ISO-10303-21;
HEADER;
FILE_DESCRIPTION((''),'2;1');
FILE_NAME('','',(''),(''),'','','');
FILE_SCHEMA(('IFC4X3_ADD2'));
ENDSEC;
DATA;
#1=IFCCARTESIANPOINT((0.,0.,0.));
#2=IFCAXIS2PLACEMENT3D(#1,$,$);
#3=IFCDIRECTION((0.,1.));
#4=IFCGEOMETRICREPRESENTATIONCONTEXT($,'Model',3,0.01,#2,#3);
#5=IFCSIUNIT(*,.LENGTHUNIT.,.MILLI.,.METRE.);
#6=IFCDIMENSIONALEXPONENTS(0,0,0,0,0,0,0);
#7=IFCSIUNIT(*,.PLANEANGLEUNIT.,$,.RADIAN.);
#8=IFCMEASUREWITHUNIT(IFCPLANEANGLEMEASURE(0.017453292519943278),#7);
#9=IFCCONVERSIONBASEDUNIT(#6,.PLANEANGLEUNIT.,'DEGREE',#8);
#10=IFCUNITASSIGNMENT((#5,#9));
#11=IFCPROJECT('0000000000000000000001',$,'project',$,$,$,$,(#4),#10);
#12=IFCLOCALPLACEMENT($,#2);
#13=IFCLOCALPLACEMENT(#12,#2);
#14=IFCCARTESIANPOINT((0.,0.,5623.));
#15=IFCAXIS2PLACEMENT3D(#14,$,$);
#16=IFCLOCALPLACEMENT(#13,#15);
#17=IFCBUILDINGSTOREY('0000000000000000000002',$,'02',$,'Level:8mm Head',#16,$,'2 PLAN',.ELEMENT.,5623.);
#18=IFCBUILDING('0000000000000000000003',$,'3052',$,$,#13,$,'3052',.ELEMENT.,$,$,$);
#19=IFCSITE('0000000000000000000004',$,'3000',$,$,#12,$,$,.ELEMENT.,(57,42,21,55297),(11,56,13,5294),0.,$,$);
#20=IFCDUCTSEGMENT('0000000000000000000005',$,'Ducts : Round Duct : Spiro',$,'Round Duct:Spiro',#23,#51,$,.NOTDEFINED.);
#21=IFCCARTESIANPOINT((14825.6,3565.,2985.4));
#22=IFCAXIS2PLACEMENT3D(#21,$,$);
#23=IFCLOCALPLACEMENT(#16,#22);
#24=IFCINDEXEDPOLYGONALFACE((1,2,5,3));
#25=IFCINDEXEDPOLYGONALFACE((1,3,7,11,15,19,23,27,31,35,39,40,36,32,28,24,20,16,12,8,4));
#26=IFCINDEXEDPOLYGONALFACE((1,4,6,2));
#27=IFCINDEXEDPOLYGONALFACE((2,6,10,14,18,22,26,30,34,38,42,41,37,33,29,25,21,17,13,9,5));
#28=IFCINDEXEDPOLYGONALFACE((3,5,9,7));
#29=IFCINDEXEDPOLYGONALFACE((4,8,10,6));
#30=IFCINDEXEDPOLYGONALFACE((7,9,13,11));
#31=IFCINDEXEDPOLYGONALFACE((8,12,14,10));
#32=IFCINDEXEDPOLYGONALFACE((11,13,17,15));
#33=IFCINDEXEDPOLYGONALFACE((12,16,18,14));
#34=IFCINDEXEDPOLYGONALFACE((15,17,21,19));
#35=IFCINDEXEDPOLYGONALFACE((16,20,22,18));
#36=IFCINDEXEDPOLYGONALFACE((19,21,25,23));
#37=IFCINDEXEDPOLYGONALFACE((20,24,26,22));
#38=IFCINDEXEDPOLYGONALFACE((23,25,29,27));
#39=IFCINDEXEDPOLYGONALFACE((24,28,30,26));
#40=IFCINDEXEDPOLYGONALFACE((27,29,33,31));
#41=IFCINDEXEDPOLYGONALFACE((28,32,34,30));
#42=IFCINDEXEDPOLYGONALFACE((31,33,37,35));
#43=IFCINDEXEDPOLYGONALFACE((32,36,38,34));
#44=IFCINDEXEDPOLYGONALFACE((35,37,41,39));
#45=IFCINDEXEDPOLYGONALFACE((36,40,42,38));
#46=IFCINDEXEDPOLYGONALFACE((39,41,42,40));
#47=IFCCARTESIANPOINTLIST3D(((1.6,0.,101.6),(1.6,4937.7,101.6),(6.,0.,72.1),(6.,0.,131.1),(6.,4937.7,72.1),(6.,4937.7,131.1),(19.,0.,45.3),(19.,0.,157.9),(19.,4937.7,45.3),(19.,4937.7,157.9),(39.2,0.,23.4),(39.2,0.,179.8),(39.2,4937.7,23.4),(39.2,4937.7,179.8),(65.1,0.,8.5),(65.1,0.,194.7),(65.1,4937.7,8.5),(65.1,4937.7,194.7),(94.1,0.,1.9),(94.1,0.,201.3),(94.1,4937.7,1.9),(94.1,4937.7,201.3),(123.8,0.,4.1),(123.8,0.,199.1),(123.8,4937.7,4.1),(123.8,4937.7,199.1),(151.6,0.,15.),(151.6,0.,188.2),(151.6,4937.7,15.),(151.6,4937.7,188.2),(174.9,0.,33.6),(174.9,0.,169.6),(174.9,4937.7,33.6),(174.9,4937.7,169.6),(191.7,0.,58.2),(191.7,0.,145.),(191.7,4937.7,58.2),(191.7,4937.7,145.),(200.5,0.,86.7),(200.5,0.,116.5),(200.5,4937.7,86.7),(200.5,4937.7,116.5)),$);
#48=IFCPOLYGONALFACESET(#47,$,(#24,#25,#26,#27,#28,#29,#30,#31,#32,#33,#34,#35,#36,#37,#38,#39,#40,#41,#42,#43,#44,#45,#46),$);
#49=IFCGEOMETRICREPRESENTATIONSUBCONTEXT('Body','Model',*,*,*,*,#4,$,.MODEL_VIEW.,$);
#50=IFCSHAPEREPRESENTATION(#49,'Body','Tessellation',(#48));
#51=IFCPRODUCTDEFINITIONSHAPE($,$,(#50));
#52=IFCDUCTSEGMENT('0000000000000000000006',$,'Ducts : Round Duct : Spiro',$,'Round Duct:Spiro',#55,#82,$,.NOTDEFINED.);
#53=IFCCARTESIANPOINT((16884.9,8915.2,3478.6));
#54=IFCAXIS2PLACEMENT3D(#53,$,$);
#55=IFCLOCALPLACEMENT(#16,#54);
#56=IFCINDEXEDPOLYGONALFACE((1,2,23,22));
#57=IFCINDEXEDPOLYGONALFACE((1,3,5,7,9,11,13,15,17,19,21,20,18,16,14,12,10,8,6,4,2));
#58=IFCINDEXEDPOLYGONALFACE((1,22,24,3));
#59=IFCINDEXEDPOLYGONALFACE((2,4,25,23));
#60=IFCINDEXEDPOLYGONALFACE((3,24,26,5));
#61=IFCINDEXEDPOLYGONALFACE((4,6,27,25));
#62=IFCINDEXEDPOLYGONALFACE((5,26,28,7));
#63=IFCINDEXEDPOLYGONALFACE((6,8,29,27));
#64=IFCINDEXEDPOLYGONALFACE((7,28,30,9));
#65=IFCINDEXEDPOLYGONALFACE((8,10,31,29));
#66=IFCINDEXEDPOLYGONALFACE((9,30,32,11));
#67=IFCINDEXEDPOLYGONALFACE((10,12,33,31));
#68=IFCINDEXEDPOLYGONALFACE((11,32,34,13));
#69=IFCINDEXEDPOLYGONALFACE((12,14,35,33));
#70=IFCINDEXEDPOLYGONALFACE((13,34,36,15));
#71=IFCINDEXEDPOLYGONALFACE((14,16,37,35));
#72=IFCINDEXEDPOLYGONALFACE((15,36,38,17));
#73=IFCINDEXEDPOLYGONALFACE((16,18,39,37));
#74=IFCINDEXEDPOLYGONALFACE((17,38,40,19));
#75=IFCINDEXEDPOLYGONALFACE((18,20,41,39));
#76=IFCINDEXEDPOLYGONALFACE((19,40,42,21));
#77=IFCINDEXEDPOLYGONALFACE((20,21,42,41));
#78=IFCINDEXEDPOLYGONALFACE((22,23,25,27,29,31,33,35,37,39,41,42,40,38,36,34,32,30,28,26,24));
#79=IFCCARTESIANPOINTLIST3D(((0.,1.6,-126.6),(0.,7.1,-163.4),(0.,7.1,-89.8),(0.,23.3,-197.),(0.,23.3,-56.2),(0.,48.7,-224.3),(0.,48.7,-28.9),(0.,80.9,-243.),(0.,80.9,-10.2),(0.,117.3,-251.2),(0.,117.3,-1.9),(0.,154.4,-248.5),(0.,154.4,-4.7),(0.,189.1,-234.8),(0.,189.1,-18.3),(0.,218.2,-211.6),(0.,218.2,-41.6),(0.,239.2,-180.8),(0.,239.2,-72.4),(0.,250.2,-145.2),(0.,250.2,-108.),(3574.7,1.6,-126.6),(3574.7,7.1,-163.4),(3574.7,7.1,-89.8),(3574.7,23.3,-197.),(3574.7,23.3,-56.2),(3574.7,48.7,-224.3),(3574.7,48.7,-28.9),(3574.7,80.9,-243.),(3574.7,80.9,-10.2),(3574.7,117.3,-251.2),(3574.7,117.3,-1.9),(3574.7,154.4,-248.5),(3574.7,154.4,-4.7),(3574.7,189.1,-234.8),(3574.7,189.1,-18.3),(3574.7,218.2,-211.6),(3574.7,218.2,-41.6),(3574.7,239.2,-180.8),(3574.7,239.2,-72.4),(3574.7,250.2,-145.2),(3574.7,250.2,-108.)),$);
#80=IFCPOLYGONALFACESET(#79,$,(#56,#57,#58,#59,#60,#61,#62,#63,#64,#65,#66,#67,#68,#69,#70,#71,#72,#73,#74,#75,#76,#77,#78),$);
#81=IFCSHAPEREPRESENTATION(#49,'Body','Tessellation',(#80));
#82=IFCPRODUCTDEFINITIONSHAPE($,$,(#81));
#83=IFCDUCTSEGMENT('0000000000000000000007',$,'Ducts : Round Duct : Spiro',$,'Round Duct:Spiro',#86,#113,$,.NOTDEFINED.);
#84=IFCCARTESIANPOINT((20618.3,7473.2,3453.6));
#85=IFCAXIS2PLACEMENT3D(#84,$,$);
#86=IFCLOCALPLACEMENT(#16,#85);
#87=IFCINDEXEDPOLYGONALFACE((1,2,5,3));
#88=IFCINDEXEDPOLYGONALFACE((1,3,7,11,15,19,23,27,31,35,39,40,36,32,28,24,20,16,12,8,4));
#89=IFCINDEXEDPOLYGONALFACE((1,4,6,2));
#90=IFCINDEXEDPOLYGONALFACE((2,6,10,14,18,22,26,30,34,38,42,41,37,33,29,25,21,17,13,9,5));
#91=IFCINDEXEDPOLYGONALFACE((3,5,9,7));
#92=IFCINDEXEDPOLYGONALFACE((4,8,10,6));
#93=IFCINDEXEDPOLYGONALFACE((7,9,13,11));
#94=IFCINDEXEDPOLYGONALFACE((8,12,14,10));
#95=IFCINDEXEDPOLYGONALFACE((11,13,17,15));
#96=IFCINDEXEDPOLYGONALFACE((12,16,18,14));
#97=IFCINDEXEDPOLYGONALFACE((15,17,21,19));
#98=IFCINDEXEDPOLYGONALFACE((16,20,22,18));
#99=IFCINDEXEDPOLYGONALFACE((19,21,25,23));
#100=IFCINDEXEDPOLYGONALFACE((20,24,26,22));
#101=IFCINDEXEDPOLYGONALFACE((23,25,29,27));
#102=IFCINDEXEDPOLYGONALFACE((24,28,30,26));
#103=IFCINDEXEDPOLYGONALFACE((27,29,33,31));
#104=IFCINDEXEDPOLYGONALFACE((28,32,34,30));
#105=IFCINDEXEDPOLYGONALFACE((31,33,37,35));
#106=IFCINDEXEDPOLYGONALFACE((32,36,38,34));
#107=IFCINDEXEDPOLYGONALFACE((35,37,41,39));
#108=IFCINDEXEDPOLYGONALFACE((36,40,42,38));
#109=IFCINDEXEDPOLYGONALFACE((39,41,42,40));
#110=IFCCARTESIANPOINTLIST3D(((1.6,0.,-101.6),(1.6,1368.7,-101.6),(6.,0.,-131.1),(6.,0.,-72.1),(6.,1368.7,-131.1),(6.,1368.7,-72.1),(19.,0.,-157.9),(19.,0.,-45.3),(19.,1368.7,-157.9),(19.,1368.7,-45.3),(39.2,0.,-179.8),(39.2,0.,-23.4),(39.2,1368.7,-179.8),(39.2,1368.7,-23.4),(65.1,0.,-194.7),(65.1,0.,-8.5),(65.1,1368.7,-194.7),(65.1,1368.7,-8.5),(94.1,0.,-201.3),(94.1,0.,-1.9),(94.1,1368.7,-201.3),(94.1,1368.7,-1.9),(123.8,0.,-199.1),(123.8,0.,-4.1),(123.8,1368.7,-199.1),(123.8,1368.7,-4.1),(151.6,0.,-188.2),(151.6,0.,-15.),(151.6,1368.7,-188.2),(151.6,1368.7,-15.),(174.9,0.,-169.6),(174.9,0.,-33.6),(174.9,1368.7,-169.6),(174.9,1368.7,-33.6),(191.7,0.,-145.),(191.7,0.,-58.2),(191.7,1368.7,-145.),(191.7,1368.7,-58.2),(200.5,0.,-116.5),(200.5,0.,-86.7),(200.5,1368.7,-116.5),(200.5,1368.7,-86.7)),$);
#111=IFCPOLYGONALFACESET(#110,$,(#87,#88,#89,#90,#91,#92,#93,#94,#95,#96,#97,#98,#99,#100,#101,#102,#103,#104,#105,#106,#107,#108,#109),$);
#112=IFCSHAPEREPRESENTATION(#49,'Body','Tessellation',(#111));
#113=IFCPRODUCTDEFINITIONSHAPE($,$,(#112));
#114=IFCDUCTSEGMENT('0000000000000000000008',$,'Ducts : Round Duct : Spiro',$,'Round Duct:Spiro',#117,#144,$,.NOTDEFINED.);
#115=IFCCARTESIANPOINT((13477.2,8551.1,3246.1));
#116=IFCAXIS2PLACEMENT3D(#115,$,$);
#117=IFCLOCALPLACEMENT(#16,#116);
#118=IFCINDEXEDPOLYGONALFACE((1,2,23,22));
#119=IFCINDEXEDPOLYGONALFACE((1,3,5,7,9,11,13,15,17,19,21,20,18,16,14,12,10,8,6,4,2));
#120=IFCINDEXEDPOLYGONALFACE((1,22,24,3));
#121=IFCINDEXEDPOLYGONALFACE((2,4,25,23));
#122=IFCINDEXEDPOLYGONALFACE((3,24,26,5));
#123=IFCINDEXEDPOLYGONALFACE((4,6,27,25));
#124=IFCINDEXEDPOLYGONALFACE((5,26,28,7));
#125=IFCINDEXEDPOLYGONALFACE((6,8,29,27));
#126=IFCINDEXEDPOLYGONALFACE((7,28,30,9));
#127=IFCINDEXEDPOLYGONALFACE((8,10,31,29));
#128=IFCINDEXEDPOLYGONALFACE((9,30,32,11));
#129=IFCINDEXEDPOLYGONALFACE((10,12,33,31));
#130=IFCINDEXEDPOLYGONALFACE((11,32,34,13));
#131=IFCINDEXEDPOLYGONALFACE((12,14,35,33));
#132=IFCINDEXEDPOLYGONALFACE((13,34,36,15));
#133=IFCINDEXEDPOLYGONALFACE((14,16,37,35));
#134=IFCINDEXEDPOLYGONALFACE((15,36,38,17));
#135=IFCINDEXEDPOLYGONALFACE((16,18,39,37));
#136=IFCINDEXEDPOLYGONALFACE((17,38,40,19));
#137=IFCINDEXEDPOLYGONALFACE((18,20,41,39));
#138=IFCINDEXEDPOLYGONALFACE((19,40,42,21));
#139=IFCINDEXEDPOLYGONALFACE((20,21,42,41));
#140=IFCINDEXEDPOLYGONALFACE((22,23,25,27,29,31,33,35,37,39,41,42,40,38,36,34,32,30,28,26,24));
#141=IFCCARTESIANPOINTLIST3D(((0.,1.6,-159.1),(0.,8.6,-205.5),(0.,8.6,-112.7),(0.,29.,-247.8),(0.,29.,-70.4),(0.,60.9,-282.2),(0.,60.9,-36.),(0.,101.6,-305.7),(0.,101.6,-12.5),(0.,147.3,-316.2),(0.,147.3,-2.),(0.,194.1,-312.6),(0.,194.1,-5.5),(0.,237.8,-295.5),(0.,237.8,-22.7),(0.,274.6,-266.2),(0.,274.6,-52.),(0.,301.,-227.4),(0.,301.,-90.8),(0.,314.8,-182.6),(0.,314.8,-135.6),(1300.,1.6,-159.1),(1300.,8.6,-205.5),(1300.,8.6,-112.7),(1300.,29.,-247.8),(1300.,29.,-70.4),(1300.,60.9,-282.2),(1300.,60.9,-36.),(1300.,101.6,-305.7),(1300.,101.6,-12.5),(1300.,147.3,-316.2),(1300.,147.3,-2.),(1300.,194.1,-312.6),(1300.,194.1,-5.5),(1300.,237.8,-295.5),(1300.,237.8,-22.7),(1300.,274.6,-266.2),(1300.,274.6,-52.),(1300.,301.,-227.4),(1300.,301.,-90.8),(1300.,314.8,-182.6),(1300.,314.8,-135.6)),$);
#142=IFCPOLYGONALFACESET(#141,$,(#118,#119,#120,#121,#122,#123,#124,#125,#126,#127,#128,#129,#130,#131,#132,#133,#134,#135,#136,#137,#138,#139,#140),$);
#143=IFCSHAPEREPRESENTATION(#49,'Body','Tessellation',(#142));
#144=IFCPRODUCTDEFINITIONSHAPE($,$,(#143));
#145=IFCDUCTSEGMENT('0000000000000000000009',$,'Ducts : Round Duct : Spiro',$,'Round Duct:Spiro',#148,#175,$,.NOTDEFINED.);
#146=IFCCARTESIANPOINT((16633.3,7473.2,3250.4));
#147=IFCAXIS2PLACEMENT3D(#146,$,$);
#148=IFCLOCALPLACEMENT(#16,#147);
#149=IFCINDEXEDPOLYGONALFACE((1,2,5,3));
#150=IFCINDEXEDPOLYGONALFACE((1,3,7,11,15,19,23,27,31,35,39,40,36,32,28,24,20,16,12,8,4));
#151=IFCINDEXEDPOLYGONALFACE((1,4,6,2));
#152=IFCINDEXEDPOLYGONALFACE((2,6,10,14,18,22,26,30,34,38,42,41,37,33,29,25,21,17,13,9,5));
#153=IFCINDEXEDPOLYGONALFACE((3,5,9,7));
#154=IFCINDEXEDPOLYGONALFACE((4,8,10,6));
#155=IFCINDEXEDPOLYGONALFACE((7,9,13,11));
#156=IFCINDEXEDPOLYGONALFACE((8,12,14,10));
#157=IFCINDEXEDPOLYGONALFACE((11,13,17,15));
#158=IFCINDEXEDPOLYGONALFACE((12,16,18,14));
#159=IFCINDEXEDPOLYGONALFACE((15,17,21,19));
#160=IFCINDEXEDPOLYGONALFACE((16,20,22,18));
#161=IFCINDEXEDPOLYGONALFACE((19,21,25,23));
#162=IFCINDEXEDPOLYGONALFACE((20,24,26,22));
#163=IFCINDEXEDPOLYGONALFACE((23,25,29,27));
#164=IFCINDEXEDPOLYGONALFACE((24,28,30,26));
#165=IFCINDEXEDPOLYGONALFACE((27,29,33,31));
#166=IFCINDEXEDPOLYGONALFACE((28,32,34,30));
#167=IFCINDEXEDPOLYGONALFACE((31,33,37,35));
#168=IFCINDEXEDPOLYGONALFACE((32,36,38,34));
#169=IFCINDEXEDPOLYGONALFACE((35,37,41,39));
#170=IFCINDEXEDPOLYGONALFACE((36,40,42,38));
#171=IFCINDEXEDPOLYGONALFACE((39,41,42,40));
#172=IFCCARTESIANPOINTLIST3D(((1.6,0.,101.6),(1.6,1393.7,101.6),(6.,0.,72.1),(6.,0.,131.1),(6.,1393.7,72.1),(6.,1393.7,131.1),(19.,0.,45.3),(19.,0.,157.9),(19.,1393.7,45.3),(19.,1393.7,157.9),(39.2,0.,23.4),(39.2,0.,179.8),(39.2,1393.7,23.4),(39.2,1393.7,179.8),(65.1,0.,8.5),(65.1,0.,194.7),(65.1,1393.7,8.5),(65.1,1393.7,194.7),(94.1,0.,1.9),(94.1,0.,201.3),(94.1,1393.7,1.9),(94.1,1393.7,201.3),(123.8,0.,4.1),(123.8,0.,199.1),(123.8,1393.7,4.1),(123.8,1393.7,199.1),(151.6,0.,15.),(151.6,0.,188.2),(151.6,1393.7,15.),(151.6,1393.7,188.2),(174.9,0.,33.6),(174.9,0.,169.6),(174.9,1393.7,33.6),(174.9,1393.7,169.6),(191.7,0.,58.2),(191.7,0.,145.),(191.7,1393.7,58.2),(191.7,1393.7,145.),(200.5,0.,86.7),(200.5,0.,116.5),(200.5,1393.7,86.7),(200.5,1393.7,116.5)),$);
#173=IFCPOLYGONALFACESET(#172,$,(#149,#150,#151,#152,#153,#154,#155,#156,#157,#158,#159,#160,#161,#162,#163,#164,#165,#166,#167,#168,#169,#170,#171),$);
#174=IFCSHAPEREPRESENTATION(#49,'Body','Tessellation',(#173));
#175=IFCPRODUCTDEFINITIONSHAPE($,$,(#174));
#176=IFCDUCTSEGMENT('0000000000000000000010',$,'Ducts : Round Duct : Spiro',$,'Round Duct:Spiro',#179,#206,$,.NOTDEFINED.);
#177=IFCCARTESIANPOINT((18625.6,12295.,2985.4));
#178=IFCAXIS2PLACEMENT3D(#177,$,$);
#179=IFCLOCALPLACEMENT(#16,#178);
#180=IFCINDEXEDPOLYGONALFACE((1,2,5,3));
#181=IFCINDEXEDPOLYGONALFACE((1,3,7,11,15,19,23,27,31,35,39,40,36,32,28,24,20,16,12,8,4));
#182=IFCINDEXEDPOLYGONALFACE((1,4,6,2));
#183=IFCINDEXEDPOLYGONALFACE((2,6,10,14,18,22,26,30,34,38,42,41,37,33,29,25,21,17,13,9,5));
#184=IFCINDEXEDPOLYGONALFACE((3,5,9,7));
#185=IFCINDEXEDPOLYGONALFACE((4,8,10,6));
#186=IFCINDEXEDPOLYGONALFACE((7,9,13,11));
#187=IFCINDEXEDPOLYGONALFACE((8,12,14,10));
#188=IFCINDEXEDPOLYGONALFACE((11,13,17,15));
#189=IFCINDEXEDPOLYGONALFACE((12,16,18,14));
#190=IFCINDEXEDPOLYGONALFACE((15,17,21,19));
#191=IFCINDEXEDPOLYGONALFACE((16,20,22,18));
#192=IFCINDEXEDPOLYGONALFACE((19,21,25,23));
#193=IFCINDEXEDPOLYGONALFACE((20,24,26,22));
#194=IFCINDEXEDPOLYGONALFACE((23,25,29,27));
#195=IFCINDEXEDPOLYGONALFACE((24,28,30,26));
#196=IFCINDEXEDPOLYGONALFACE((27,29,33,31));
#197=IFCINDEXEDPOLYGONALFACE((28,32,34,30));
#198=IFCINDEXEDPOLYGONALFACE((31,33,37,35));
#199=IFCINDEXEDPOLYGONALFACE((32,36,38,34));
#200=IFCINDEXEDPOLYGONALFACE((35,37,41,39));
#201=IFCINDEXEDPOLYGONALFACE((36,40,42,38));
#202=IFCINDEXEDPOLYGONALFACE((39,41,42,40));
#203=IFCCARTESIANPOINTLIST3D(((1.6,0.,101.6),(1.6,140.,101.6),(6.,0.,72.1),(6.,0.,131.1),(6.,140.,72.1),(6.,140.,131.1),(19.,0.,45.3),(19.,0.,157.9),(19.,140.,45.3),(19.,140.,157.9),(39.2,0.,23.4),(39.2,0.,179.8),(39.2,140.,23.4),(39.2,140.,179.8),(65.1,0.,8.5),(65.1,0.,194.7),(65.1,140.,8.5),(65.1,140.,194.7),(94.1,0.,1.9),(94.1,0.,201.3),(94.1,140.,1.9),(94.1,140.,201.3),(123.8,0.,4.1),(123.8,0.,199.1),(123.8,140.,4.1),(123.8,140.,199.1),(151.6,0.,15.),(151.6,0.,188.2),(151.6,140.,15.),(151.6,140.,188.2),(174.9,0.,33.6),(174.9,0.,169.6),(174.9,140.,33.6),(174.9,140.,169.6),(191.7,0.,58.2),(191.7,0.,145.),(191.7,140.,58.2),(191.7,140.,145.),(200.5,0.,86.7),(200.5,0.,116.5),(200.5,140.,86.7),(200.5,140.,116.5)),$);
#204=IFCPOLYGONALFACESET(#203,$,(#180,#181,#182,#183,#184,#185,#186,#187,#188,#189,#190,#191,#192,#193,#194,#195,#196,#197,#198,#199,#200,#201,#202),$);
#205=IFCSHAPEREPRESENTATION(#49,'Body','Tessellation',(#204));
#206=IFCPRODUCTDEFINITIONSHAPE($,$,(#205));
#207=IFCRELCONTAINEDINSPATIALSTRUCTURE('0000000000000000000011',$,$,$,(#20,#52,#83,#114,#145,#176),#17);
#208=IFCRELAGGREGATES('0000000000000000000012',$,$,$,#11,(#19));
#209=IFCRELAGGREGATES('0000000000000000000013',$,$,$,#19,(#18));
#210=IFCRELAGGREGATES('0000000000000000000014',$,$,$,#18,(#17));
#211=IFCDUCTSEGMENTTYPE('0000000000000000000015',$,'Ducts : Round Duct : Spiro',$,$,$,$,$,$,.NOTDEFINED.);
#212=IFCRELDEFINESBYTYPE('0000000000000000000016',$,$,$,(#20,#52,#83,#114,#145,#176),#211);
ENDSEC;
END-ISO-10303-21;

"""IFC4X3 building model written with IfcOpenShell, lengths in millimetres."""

from ifc_helpers import new_model, entity, si_unit, converted_unit, direction, frame, frame_2d, origin, origin_2d_with_axis, place, context, subcontext, project, spatial, circle, extrude, type_object, element, save


model = new_model("IFC4X3")

# Units and contexts
model_context = context("Model", 3, precision=0.01, world=origin(), true_north=direction((0.0, 1.0)))
body_context = subcontext(model_context, "Body", "Model", "MODEL_VIEW")
ifc_project = project(units=[si_unit("LENGTHUNIT", "METRE", prefix="MILLI"), converted_unit("PLANEANGLEUNIT", "DEGREE", entity("IfcPlaneAngleMeasure", 0.017453292519943278), si_unit("PLANEANGLEUNIT", "RADIAN"), dimensions=[0, 0, 0, 0, 0, 0, 0])], contexts=[model_context])

# Site, building, storey
site_placement = place(None, origin())
site = spatial("IfcSite", under=ifc_project, at=site_placement, Name="3000", CompositionType="ELEMENT", RefLatitude=(57, 42, 21, 55297), RefLongitude=(11, 56, 13, 5294), RefElevation=0.0)
building_placement = place(site_placement, origin())
building = spatial("IfcBuilding", under=site, at=building_placement, Name="3052", LongName="3052", CompositionType="ELEMENT")
storey_placement = place(building_placement, frame((0.0, 0.0, 5623.0)))
storey = spatial("IfcBuildingStorey", under=building, at=storey_placement, Name="02", ObjectType="Level:8mm Head", LongName="2 PLAN", CompositionType="ELEMENT", Elevation=5623.0)

# Duct segments
duct_segment_type = type_object("IfcDuctSegmentType", Name="Ducts : Round Duct : Spiro", PredefinedType="NOTDEFINED")
duct_segment_1_placement = place(storey_placement, frame((14825.6, 3565.0, 2985.4)))
element("IfcDuctSegment", 1, at=duct_segment_1_placement, inside=storey, type_object=duct_segment_type, Name="Ducts : Round Duct : Spiro", ObjectType="Round Duct:Spiro", PredefinedType="NOTDEFINED", context=body_context, shape_type="SweptSolid", body=[
    extrude(circle(Radius=100.0, at=frame_2d((0.0, 0.0), x_axis=(1.0, 0.0))), frame((101.6, 0.0, 101.6), z_axis=(0.0, 1.0, 0.0), x_axis=(-1.0, 0.0, 0.0)), (0.0, 0.0, 1.0), 4937.7),
])
duct_segment_2_placement = place(storey_placement, frame((16884.9, 8915.2, 3478.6)))
element("IfcDuctSegment", 2, at=duct_segment_2_placement, inside=storey, type_object=duct_segment_type, Name="Ducts : Round Duct : Spiro", ObjectType="Round Duct:Spiro", PredefinedType="NOTDEFINED", context=body_context, shape_type="SweptSolid", body=[
    extrude(circle(Radius=125.0, at=frame_2d((0.0, 0.0), x_axis=(1.0, 0.0))), frame((0.0, 126.6, -126.6), z_axis=(1.0, 0.0, 0.0), x_axis=(0.0, -1.0, 0.0)), (0.0, 0.0, 1.0), 3574.7),
])
duct_segment_3_placement = place(storey_placement, frame((20618.3, 7473.2, 3453.6)))
element("IfcDuctSegment", 3, at=duct_segment_3_placement, inside=storey, type_object=duct_segment_type, Name="Ducts : Round Duct : Spiro", ObjectType="Round Duct:Spiro", PredefinedType="NOTDEFINED", context=body_context, shape_type="SweptSolid", body=[
    extrude(circle(Radius=100.0, at=frame_2d((0.0, 0.0), x_axis=(1.0, 0.0))), frame((101.6, 0.0, -101.6), z_axis=(0.0, 1.0, 0.0), x_axis=(-1.0, 0.0, 0.0)), (0.0, 0.0, 1.0), 1368.7),
])
duct_segment_4_placement = place(storey_placement, frame((13477.2, 8551.1, 3246.1)))
element("IfcDuctSegment", 4, at=duct_segment_4_placement, inside=storey, type_object=duct_segment_type, Name="Ducts : Round Duct : Spiro", ObjectType="Round Duct:Spiro", PredefinedType="NOTDEFINED", context=body_context, shape_type="SweptSolid", body=[
    extrude(circle(Radius=157.5, at=frame_2d((0.0, 0.0), x_axis=(1.0, 0.0))), frame((0.0, 159.1, -159.1), z_axis=(1.0, 0.0, 0.0), x_axis=(0.0, -1.0, 0.0)), (0.0, 0.0, 1.0), 1300.0),
])
duct_segment_5_placement = place(storey_placement, frame((16633.3, 7473.2, 3250.4)))
element("IfcDuctSegment", 5, at=duct_segment_5_placement, inside=storey, type_object=duct_segment_type, Name="Ducts : Round Duct : Spiro", ObjectType="Round Duct:Spiro", PredefinedType="NOTDEFINED", context=body_context, shape_type="SweptSolid", body=[
    extrude(circle(Radius=100.0, at=origin_2d_with_axis()), frame((101.6, 0.0, 101.6), z_axis=(0.0, 1.0, 0.0), x_axis=(-1.0, 0.0, 0.0)), (0.0, 0.0, 1.0), 1393.7),
])
duct_segment_6_placement = place(storey_placement, frame((18625.6, 12295.0, 2985.4)))
element("IfcDuctSegment", 6, at=duct_segment_6_placement, inside=storey, type_object=duct_segment_type, Name="Ducts : Round Duct : Spiro", ObjectType="Round Duct:Spiro", PredefinedType="NOTDEFINED", context=body_context, shape_type="SweptSolid", body=[
    extrude(circle(Radius=100.0, at=frame_2d((0.0, 0.0), x_axis=(1.0, 0.0))), frame((101.6, 0.0, 101.6), z_axis=(0.0, 1.0, 0.0), x_axis=(-1.0, 0.0, 0.0)), (0.0, 0.0, 1.0), 140.0),
])

save(model, "model.ifc")
